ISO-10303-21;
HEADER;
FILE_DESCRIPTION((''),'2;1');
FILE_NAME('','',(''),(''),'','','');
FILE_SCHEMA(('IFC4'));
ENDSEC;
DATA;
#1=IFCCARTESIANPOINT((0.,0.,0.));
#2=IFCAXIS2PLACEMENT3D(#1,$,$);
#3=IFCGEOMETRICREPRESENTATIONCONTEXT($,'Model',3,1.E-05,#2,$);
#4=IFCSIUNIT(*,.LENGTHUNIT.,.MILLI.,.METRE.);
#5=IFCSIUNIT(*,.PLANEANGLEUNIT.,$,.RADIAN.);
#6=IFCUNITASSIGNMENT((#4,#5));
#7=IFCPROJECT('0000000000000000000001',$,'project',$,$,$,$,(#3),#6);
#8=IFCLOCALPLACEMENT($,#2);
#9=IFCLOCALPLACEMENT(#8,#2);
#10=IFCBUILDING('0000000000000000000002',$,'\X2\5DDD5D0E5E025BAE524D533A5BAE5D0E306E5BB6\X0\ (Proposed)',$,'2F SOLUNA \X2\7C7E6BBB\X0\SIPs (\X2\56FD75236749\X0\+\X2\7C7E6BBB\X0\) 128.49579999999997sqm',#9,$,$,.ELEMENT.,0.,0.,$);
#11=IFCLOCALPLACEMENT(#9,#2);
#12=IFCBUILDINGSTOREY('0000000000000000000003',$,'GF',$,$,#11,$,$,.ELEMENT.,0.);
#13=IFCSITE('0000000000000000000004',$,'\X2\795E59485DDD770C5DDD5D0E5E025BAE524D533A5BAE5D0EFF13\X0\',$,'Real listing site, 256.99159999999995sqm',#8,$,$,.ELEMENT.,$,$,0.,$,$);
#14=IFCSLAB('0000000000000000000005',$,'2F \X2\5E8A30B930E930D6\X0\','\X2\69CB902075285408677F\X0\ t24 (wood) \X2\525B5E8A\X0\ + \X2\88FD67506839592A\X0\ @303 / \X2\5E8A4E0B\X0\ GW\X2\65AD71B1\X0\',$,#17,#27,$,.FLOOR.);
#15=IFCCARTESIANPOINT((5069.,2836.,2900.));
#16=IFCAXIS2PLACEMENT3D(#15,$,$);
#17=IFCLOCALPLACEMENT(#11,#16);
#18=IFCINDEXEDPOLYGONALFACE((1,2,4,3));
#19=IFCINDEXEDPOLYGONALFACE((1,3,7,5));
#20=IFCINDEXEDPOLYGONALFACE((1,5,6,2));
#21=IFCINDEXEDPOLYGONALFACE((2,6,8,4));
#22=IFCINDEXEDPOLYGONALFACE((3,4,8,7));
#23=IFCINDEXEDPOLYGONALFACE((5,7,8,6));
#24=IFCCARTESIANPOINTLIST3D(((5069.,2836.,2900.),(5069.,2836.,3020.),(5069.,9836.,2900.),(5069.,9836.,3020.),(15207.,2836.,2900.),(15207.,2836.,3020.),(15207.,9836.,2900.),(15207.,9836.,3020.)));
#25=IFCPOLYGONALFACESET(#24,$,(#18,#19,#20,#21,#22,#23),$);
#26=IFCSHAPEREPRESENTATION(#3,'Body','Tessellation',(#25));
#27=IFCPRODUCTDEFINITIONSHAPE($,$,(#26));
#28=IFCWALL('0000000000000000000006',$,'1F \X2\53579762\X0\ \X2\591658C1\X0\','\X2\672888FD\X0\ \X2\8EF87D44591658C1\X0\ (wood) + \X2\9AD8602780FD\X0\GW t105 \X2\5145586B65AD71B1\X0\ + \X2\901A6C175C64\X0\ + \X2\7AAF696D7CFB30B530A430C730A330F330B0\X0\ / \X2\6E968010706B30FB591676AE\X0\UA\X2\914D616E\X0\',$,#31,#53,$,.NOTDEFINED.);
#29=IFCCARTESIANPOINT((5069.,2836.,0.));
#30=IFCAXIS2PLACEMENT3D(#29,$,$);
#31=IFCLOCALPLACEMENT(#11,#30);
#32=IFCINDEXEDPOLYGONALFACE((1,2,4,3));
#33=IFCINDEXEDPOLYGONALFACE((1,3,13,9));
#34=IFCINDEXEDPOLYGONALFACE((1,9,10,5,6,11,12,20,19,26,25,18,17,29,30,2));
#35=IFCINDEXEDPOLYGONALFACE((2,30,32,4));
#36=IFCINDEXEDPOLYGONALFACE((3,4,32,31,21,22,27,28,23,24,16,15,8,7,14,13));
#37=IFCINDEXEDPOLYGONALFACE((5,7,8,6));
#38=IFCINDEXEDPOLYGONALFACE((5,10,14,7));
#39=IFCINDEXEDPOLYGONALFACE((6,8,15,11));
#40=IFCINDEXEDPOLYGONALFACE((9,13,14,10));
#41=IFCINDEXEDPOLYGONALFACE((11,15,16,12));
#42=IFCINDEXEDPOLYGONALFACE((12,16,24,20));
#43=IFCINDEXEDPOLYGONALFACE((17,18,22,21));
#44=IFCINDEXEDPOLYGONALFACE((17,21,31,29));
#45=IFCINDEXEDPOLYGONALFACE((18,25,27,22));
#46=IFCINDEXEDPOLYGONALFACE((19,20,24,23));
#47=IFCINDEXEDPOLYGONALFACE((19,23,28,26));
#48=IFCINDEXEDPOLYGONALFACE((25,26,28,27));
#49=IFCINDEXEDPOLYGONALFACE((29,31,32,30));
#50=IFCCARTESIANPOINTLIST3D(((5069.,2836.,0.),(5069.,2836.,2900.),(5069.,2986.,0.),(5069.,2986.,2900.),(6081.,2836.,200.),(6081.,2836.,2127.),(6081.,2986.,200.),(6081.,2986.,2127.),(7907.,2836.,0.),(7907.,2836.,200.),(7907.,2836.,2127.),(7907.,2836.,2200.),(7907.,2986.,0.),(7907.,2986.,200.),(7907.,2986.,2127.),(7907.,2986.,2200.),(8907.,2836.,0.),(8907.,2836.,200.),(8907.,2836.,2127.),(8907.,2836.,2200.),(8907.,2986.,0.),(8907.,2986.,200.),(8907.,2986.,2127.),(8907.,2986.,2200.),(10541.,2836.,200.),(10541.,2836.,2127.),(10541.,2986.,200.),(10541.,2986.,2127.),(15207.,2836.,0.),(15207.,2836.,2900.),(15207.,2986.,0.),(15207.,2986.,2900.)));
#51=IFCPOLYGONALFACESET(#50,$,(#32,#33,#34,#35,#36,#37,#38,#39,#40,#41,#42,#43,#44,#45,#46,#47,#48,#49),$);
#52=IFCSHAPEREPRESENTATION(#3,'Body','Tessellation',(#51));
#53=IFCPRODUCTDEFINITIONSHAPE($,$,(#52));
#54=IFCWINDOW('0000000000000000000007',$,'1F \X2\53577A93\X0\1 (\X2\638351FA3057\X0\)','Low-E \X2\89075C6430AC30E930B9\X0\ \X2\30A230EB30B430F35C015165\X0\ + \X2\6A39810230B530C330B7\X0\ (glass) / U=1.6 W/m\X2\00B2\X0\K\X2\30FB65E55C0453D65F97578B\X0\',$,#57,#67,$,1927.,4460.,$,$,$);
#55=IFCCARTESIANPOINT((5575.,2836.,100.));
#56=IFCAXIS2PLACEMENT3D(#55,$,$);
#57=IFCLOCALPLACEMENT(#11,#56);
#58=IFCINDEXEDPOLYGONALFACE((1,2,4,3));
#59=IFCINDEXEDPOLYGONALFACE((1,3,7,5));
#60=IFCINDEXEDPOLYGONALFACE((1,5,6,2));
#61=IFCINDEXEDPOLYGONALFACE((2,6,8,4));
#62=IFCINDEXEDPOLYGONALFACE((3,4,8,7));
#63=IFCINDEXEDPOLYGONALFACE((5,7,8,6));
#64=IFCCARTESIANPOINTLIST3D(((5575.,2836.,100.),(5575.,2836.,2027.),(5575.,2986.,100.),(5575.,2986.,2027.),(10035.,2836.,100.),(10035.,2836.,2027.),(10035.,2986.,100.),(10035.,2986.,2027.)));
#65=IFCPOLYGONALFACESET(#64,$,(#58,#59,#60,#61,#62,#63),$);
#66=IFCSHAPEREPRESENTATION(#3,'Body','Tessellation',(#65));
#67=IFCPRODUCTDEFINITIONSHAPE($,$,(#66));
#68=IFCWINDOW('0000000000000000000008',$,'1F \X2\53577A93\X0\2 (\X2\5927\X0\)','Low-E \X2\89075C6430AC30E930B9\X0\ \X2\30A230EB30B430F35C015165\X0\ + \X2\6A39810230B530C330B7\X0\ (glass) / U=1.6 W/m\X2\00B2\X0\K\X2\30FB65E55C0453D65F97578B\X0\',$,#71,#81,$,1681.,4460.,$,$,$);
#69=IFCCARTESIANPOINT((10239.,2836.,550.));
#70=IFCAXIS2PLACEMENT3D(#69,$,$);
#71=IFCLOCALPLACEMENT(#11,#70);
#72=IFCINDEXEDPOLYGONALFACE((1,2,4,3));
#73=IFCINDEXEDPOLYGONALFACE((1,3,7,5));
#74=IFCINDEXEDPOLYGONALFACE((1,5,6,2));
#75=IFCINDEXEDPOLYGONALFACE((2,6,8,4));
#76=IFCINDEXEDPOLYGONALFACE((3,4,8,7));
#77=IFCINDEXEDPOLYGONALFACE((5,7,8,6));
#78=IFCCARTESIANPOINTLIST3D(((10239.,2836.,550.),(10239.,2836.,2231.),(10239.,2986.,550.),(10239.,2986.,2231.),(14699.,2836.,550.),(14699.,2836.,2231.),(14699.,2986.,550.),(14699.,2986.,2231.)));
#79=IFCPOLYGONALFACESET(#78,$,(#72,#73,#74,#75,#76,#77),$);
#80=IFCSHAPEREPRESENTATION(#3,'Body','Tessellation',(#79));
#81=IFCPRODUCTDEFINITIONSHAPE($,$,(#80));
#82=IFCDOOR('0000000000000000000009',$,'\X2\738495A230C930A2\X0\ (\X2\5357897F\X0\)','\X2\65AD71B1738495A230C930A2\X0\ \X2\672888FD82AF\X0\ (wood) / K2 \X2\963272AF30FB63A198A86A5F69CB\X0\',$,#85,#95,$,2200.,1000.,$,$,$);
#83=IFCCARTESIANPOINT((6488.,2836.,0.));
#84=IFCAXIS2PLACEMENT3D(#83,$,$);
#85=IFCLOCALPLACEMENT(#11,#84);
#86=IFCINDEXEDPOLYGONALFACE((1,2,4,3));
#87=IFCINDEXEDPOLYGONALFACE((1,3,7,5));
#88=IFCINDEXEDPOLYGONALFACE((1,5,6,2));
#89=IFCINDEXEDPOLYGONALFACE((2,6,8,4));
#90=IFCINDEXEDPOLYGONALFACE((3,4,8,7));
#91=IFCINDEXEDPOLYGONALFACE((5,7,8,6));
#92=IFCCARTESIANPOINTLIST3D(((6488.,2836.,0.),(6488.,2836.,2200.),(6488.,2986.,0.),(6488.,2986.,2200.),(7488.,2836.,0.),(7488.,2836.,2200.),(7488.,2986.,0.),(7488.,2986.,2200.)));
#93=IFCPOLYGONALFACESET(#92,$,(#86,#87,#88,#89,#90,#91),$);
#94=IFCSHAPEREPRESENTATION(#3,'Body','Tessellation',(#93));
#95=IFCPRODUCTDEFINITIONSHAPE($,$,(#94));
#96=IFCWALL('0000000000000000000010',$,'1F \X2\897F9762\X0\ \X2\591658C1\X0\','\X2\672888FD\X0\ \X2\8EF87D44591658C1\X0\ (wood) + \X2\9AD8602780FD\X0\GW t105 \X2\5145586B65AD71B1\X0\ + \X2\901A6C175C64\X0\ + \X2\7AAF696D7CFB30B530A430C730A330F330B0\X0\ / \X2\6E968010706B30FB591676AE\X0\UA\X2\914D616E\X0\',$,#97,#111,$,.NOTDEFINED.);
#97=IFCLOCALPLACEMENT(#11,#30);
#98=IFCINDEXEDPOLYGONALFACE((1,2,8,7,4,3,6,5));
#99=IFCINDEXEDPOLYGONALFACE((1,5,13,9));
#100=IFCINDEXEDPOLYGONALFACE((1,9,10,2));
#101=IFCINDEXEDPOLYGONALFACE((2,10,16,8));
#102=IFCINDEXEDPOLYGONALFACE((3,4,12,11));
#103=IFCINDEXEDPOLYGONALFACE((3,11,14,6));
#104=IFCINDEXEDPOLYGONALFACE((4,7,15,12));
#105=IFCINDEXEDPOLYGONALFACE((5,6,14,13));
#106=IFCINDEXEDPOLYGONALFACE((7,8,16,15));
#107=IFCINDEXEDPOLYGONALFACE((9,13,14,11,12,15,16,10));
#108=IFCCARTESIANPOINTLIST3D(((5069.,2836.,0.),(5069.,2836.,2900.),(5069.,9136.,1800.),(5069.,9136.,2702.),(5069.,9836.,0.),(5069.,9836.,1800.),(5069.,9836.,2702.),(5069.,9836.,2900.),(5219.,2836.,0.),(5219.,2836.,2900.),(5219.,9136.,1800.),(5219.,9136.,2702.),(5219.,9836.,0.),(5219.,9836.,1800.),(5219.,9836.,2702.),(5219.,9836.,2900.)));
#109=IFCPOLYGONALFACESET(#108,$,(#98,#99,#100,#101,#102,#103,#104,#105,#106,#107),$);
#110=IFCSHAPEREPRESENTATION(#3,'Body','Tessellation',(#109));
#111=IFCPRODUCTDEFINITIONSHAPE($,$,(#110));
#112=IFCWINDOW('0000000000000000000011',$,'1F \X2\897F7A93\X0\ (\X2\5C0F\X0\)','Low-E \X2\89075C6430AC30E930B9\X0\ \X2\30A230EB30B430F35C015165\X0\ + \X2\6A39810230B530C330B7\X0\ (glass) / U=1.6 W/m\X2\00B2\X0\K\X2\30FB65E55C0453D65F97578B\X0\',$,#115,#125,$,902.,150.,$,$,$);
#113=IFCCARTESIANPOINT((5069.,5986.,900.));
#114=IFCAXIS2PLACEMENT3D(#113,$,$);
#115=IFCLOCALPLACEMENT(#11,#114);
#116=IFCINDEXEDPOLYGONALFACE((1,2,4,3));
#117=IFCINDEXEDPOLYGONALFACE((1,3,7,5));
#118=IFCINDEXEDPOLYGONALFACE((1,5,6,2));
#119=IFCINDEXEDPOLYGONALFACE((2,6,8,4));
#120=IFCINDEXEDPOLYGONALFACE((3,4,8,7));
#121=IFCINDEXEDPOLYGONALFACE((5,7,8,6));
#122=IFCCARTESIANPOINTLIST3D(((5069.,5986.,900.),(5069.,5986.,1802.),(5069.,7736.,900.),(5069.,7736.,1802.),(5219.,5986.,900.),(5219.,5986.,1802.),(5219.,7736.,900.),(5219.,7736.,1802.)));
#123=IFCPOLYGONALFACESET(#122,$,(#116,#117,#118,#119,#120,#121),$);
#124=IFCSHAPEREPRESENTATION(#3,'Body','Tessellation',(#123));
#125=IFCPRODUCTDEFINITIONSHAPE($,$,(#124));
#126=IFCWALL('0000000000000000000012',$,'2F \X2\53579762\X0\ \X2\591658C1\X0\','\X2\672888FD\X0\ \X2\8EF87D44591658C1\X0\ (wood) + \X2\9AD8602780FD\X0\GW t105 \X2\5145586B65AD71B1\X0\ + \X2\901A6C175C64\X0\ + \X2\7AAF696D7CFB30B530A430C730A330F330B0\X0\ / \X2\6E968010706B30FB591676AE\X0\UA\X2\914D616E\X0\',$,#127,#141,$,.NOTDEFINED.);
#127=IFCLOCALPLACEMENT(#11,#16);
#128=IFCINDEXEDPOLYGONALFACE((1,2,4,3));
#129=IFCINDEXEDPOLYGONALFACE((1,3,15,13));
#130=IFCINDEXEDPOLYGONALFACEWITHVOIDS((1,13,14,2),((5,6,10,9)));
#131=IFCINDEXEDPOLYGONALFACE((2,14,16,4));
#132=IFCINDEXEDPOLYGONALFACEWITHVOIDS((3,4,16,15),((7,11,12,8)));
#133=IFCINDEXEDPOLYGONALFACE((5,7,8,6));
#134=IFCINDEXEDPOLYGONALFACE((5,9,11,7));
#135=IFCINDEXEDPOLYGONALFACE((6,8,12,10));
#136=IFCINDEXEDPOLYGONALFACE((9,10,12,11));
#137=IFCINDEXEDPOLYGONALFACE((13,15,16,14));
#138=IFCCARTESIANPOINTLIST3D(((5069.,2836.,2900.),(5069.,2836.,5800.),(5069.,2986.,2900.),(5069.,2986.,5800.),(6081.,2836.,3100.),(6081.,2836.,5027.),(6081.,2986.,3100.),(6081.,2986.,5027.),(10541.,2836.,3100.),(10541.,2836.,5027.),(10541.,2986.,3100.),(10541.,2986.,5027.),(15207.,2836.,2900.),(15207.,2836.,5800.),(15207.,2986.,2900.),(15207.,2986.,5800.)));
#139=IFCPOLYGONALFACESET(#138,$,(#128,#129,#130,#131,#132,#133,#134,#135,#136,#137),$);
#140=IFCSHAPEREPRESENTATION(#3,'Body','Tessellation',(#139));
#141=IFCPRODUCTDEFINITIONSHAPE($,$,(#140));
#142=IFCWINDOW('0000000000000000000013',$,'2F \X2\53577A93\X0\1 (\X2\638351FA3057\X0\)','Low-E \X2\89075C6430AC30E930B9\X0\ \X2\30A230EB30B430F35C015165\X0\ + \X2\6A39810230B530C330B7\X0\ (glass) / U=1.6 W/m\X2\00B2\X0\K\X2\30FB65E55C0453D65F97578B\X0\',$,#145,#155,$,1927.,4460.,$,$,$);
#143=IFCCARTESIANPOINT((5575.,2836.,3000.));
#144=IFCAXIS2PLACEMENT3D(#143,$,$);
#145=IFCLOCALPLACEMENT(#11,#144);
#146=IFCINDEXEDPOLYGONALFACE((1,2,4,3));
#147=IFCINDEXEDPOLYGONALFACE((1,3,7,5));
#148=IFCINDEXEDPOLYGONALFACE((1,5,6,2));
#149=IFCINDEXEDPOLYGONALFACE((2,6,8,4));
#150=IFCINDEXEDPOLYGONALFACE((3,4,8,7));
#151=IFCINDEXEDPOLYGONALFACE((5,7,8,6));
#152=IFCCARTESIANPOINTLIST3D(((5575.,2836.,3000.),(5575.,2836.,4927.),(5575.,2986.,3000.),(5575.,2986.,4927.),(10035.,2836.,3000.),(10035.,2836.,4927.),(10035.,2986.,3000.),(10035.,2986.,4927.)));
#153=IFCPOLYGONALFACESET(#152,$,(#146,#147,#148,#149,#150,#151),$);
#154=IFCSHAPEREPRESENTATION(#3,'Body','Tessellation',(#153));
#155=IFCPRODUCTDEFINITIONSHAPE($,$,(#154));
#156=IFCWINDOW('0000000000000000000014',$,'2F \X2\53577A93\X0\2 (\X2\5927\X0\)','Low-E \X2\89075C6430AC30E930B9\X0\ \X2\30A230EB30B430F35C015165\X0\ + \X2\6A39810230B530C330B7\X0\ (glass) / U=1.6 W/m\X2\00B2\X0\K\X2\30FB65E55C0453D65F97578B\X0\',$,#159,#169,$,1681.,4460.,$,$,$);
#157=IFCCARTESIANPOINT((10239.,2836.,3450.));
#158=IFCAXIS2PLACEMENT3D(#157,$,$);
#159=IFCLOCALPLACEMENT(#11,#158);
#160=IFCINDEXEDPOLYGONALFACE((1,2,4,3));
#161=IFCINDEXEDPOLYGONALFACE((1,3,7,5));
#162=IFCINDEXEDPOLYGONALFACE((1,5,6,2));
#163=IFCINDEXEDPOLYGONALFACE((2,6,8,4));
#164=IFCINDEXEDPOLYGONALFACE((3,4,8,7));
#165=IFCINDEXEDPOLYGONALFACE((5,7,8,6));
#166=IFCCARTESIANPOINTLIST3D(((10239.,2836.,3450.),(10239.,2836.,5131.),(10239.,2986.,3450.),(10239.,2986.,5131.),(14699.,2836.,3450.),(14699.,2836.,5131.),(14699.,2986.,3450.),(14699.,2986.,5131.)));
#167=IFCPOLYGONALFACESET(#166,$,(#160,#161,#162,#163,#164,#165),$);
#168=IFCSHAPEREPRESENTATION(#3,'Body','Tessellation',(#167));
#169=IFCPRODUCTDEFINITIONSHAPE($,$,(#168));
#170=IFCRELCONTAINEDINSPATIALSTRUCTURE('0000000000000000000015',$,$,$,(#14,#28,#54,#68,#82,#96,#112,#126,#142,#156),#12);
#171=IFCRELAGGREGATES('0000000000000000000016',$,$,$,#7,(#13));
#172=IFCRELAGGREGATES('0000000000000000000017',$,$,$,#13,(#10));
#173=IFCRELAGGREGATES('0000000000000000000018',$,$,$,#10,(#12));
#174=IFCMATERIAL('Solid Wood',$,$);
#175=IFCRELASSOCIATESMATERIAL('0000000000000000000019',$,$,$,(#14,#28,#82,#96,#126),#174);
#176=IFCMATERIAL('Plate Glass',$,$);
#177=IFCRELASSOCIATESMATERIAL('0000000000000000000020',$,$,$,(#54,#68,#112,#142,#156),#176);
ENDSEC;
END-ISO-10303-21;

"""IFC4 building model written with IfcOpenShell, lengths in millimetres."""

from ifc_helpers import new_model, si_unit, frame, frame_2d, origin, place, context, project, spatial, rectangle, extrude, material, element, fill, save


model = new_model("IFC4")

# Units and contexts
model_context = context("Model", 3, precision=1e-05, world=origin())
ifc_project = project(units=[si_unit("LENGTHUNIT", "METRE", prefix="MILLI"), si_unit("PLANEANGLEUNIT", "RADIAN")], contexts=[model_context])

# Site, building, storey
site_placement = place(None, origin())
site = spatial("IfcSite", under=ifc_project, at=site_placement, Name="神奈川県川崎市宮前区宮崎３", ObjectType="Real listing site, 256.99159999999995sqm", CompositionType="ELEMENT", RefElevation=0.0)
building_placement = place(site_placement, origin())
building = spatial("IfcBuilding", under=site, at=building_placement, Name="川崎市宮前区宮崎の家 (Proposed)", ObjectType="2F SOLUNA 籾殻SIPs (国産杉+籾殻) 128.49579999999997sqm", CompositionType="ELEMENT", ElevationOfRefHeight=0.0, ElevationOfTerrain=0.0)
storey_placement = place(building_placement, origin())
storey = spatial("IfcBuildingStorey", under=building, at=storey_placement, Name="GF", CompositionType="ELEMENT", Elevation=0.0)

# Slab
ifc_material_1 = material(Name="Solid Wood")
slab_1_placement = place(storey_placement, frame((5069.0, 2836.0, 2900.0)))
element("IfcSlab", 1, at=slab_1_placement, inside=storey, material=ifc_material_1, Name="2F 床スラブ", Description="構造用合板 t24 (wood) 剛床 + 製材根太 @303 / 床下 GW断熱", PredefinedType="FLOOR", context=model_context, shape_type="SweptSolid", body=[
    extrude(rectangle(XDim=10138.0, YDim=7000.0, at=frame_2d((5069.0, 3500.0))), frame((5069.0, 2836.0, 2900.0)), (0.0, 0.0, 1.0), 120.0),
])

# Wall, openings, windows, door
wall_1_placement = place(storey_placement, frame((5069.0, 2836.0, 0.0)))
wall_1 = element("IfcWall", 2, at=wall_1_placement, inside=storey, material=ifc_material_1, Name="1F 南面 外壁", Description="木製 軸組外壁 (wood) + 高性能GW t105 充填断熱 + 通気層 + 窯業系サイディング / 準耐火・外皮UA配慮", PredefinedType="NOTDEFINED", context=model_context, shape_type="SweptSolid", body=[
    extrude(rectangle(XDim=10138.0, YDim=150.0, at=frame_2d((5069.0, 75.0))), frame((5069.0, 2836.0, 0.0)), (0.0, 0.0, 1.0), 2900.0),
])
opening_1_placement = place(storey_placement, frame((5575.0, 2836.0, 100.0)))
opening_1 = element("IfcOpeningElement", 3, at=opening_1_placement, cuts=wall_1, PredefinedType="NOTDEFINED", context=model_context, shape_type="SweptSolid", body=[
    extrude(rectangle(XDim=4460.0, YDim=150.0, at=frame_2d((2230.0, 75.0))), frame((5575.0, 2836.0, 100.0)), (0.0, 0.0, 1.0), 1927.0),
])
opening_2_placement = place(storey_placement, frame((10239.0, 2836.0, 550.0)))
opening_2 = element("IfcOpeningElement", 4, at=opening_2_placement, cuts=wall_1, PredefinedType="NOTDEFINED", context=model_context, shape_type="SweptSolid", body=[
    extrude(rectangle(XDim=4460.0, YDim=150.0, at=frame_2d((2230.0, 75.0))), frame((10239.0, 2836.0, 550.0)), (0.0, 0.0, 1.0), 1681.0),
])
opening_3_placement = place(storey_placement, frame((6488.0, 2836.0, 0.0)))
opening_3 = element("IfcOpeningElement", 5, at=opening_3_placement, cuts=wall_1, PredefinedType="NOTDEFINED", context=model_context, shape_type="SweptSolid", body=[
    extrude(rectangle(XDim=1000.0, YDim=150.0, at=frame_2d((500.0, 75.0))), frame((6488.0, 2836.0, 0.0)), (0.0, 0.0, 1.0), 2200.0),
])
ifc_material_2 = material(Name="Plate Glass")
window_1_placement = place(storey_placement, frame((5575.0, 2836.0, 100.0)))
window_1 = element("IfcWindow", 6, at=window_1_placement, inside=storey, material=ifc_material_2, Name="1F 南窓1 (掃出し)", Description="Low-E 複層ガラス アルゴン封入 + 樹脂サッシ (glass) / U=1.6 W/m²K・日射取得型", OverallHeight=1927.0, OverallWidth=4460.0, context=model_context, shape_type="SweptSolid", body=[
    extrude(rectangle(XDim=4460.0, YDim=150.0, at=frame_2d((2230.0, 75.0))), frame((5575.0, 2836.0, 100.0)), (0.0, 0.0, 1.0), 1927.0),
])
fill(opening_1, window_1)
window_2_placement = place(storey_placement, frame((10239.0, 2836.0, 550.0)))
window_2 = element("IfcWindow", 7, at=window_2_placement, inside=storey, material=ifc_material_2, Name="1F 南窓2 (大)", Description="Low-E 複層ガラス アルゴン封入 + 樹脂サッシ (glass) / U=1.6 W/m²K・日射取得型", OverallHeight=1681.0, OverallWidth=4460.0, context=model_context, shape_type="SweptSolid", body=[
    extrude(rectangle(XDim=4460.0, YDim=150.0, at=frame_2d((2230.0, 75.0))), frame((10239.0, 2836.0, 550.0)), (0.0, 0.0, 1.0), 1681.0),
])
fill(opening_2, window_2)
door_placement = place(storey_placement, frame((6488.0, 2836.0, 0.0)))
door = element("IfcDoor", 8, at=door_placement, inside=storey, material=ifc_material_1, Name="玄関ドア (南西)", Description="断熱玄関ドア 木製芯 (wood) / K2 防犯・採風機構", OverallHeight=2200.0, OverallWidth=1000.0, context=model_context, shape_type="SweptSolid", body=[
    extrude(rectangle(XDim=1000.0, YDim=150.0, at=frame_2d((500.0, 75.0))), frame((6488.0, 2836.0, 0.0)), (0.0, 0.0, 1.0), 2200.0),
])
fill(opening_3, door)

# Wall, opening, window
wall_2_placement = place(storey_placement, frame((5069.0, 2836.0, 0.0)))
wall_2 = element("IfcWall", 9, at=wall_2_placement, inside=storey, material=ifc_material_1, Name="1F 西面 外壁", Description="木製 軸組外壁 (wood) + 高性能GW t105 充填断熱 + 通気層 + 窯業系サイディング / 準耐火・外皮UA配慮", PredefinedType="NOTDEFINED", context=model_context, shape_type="SweptSolid", body=[
    extrude(rectangle(XDim=150.0, YDim=7000.0, at=frame_2d((75.0, 3500.0))), frame((5069.0, 2836.0, 0.0)), (0.0, 0.0, 1.0), 2900.0),
])
opening_4_placement = place(storey_placement, frame((5069.0, 5986.0, 900.0)))
opening_4 = element("IfcOpeningElement", 10, at=opening_4_placement, cuts=wall_2, PredefinedType="NOTDEFINED", context=model_context, shape_type="SweptSolid", body=[
    extrude(rectangle(XDim=150.0, YDim=1750.0, at=frame_2d((75.0, 875.0))), frame((5069.0, 5986.0, 900.0)), (0.0, 0.0, 1.0), 902.0),
])
window_3_placement = place(storey_placement, frame((5069.0, 5986.0, 900.0)))
window_3 = element("IfcWindow", 11, at=window_3_placement, inside=storey, material=ifc_material_2, Name="1F 西窓 (小)", Description="Low-E 複層ガラス アルゴン封入 + 樹脂サッシ (glass) / U=1.6 W/m²K・日射取得型", OverallHeight=902.0, OverallWidth=150.0, context=model_context, shape_type="SweptSolid", body=[
    extrude(rectangle(XDim=150.0, YDim=1750.0, at=frame_2d((75.0, 875.0))), frame((5069.0, 5986.0, 900.0)), (0.0, 0.0, 1.0), 902.0),
])
fill(opening_4, window_3)

# Wall, openings, windows
wall_3_placement = place(storey_placement, frame((5069.0, 2836.0, 2900.0)))
wall_3 = element("IfcWall", 12, at=wall_3_placement, inside=storey, material=ifc_material_1, Name="2F 南面 外壁", Description="木製 軸組外壁 (wood) + 高性能GW t105 充填断熱 + 通気層 + 窯業系サイディング / 準耐火・外皮UA配慮", PredefinedType="NOTDEFINED", context=model_context, shape_type="SweptSolid", body=[
    extrude(rectangle(XDim=10138.0, YDim=150.0, at=frame_2d((5069.0, 75.0))), frame((5069.0, 2836.0, 2900.0)), (0.0, 0.0, 1.0), 2900.0),
])
opening_5_placement = place(storey_placement, frame((5575.0, 2836.0, 3000.0)))
opening_5 = element("IfcOpeningElement", 13, at=opening_5_placement, cuts=wall_3, PredefinedType="NOTDEFINED", context=model_context, shape_type="SweptSolid", body=[
    extrude(rectangle(XDim=4460.0, YDim=150.0, at=frame_2d((2230.0, 75.0))), frame((5575.0, 2836.0, 3000.0)), (0.0, 0.0, 1.0), 1927.0),
])
opening_6_placement = place(storey_placement, frame((10239.0, 2836.0, 3450.0)))
opening_6 = element("IfcOpeningElement", 14, at=opening_6_placement, cuts=wall_3, PredefinedType="NOTDEFINED", context=model_context, shape_type="SweptSolid", body=[
    extrude(rectangle(XDim=4460.0, YDim=150.0, at=frame_2d((2230.0, 75.0))), frame((10239.0, 2836.0, 3450.0)), (0.0, 0.0, 1.0), 1681.0),
])
window_4_placement = place(storey_placement, frame((5575.0, 2836.0, 3000.0)))
window_4 = element("IfcWindow", 15, at=window_4_placement, inside=storey, material=ifc_material_2, Name="2F 南窓1 (掃出し)", Description="Low-E 複層ガラス アルゴン封入 + 樹脂サッシ (glass) / U=1.6 W/m²K・日射取得型", OverallHeight=1927.0, OverallWidth=4460.0, context=model_context, shape_type="SweptSolid", body=[
    extrude(rectangle(XDim=4460.0, YDim=150.0, at=frame_2d((2230.0, 75.0))), frame((5575.0, 2836.0, 3000.0)), (0.0, 0.0, 1.0), 1927.0),
])
fill(opening_5, window_4)
window_5_placement = place(storey_placement, frame((10239.0, 2836.0, 3450.0)))
window_5 = element("IfcWindow", 16, at=window_5_placement, inside=storey, material=ifc_material_2, Name="2F 南窓2 (大)", Description="Low-E 複層ガラス アルゴン封入 + 樹脂サッシ (glass) / U=1.6 W/m²K・日射取得型", OverallHeight=1681.0, OverallWidth=4460.0, context=model_context, shape_type="SweptSolid", body=[
    extrude(rectangle(XDim=4460.0, YDim=150.0, at=frame_2d((2230.0, 75.0))), frame((10239.0, 2836.0, 3450.0)), (0.0, 0.0, 1.0), 1681.0),
])
fill(opening_6, window_5)

save(model, "model.ifc")
